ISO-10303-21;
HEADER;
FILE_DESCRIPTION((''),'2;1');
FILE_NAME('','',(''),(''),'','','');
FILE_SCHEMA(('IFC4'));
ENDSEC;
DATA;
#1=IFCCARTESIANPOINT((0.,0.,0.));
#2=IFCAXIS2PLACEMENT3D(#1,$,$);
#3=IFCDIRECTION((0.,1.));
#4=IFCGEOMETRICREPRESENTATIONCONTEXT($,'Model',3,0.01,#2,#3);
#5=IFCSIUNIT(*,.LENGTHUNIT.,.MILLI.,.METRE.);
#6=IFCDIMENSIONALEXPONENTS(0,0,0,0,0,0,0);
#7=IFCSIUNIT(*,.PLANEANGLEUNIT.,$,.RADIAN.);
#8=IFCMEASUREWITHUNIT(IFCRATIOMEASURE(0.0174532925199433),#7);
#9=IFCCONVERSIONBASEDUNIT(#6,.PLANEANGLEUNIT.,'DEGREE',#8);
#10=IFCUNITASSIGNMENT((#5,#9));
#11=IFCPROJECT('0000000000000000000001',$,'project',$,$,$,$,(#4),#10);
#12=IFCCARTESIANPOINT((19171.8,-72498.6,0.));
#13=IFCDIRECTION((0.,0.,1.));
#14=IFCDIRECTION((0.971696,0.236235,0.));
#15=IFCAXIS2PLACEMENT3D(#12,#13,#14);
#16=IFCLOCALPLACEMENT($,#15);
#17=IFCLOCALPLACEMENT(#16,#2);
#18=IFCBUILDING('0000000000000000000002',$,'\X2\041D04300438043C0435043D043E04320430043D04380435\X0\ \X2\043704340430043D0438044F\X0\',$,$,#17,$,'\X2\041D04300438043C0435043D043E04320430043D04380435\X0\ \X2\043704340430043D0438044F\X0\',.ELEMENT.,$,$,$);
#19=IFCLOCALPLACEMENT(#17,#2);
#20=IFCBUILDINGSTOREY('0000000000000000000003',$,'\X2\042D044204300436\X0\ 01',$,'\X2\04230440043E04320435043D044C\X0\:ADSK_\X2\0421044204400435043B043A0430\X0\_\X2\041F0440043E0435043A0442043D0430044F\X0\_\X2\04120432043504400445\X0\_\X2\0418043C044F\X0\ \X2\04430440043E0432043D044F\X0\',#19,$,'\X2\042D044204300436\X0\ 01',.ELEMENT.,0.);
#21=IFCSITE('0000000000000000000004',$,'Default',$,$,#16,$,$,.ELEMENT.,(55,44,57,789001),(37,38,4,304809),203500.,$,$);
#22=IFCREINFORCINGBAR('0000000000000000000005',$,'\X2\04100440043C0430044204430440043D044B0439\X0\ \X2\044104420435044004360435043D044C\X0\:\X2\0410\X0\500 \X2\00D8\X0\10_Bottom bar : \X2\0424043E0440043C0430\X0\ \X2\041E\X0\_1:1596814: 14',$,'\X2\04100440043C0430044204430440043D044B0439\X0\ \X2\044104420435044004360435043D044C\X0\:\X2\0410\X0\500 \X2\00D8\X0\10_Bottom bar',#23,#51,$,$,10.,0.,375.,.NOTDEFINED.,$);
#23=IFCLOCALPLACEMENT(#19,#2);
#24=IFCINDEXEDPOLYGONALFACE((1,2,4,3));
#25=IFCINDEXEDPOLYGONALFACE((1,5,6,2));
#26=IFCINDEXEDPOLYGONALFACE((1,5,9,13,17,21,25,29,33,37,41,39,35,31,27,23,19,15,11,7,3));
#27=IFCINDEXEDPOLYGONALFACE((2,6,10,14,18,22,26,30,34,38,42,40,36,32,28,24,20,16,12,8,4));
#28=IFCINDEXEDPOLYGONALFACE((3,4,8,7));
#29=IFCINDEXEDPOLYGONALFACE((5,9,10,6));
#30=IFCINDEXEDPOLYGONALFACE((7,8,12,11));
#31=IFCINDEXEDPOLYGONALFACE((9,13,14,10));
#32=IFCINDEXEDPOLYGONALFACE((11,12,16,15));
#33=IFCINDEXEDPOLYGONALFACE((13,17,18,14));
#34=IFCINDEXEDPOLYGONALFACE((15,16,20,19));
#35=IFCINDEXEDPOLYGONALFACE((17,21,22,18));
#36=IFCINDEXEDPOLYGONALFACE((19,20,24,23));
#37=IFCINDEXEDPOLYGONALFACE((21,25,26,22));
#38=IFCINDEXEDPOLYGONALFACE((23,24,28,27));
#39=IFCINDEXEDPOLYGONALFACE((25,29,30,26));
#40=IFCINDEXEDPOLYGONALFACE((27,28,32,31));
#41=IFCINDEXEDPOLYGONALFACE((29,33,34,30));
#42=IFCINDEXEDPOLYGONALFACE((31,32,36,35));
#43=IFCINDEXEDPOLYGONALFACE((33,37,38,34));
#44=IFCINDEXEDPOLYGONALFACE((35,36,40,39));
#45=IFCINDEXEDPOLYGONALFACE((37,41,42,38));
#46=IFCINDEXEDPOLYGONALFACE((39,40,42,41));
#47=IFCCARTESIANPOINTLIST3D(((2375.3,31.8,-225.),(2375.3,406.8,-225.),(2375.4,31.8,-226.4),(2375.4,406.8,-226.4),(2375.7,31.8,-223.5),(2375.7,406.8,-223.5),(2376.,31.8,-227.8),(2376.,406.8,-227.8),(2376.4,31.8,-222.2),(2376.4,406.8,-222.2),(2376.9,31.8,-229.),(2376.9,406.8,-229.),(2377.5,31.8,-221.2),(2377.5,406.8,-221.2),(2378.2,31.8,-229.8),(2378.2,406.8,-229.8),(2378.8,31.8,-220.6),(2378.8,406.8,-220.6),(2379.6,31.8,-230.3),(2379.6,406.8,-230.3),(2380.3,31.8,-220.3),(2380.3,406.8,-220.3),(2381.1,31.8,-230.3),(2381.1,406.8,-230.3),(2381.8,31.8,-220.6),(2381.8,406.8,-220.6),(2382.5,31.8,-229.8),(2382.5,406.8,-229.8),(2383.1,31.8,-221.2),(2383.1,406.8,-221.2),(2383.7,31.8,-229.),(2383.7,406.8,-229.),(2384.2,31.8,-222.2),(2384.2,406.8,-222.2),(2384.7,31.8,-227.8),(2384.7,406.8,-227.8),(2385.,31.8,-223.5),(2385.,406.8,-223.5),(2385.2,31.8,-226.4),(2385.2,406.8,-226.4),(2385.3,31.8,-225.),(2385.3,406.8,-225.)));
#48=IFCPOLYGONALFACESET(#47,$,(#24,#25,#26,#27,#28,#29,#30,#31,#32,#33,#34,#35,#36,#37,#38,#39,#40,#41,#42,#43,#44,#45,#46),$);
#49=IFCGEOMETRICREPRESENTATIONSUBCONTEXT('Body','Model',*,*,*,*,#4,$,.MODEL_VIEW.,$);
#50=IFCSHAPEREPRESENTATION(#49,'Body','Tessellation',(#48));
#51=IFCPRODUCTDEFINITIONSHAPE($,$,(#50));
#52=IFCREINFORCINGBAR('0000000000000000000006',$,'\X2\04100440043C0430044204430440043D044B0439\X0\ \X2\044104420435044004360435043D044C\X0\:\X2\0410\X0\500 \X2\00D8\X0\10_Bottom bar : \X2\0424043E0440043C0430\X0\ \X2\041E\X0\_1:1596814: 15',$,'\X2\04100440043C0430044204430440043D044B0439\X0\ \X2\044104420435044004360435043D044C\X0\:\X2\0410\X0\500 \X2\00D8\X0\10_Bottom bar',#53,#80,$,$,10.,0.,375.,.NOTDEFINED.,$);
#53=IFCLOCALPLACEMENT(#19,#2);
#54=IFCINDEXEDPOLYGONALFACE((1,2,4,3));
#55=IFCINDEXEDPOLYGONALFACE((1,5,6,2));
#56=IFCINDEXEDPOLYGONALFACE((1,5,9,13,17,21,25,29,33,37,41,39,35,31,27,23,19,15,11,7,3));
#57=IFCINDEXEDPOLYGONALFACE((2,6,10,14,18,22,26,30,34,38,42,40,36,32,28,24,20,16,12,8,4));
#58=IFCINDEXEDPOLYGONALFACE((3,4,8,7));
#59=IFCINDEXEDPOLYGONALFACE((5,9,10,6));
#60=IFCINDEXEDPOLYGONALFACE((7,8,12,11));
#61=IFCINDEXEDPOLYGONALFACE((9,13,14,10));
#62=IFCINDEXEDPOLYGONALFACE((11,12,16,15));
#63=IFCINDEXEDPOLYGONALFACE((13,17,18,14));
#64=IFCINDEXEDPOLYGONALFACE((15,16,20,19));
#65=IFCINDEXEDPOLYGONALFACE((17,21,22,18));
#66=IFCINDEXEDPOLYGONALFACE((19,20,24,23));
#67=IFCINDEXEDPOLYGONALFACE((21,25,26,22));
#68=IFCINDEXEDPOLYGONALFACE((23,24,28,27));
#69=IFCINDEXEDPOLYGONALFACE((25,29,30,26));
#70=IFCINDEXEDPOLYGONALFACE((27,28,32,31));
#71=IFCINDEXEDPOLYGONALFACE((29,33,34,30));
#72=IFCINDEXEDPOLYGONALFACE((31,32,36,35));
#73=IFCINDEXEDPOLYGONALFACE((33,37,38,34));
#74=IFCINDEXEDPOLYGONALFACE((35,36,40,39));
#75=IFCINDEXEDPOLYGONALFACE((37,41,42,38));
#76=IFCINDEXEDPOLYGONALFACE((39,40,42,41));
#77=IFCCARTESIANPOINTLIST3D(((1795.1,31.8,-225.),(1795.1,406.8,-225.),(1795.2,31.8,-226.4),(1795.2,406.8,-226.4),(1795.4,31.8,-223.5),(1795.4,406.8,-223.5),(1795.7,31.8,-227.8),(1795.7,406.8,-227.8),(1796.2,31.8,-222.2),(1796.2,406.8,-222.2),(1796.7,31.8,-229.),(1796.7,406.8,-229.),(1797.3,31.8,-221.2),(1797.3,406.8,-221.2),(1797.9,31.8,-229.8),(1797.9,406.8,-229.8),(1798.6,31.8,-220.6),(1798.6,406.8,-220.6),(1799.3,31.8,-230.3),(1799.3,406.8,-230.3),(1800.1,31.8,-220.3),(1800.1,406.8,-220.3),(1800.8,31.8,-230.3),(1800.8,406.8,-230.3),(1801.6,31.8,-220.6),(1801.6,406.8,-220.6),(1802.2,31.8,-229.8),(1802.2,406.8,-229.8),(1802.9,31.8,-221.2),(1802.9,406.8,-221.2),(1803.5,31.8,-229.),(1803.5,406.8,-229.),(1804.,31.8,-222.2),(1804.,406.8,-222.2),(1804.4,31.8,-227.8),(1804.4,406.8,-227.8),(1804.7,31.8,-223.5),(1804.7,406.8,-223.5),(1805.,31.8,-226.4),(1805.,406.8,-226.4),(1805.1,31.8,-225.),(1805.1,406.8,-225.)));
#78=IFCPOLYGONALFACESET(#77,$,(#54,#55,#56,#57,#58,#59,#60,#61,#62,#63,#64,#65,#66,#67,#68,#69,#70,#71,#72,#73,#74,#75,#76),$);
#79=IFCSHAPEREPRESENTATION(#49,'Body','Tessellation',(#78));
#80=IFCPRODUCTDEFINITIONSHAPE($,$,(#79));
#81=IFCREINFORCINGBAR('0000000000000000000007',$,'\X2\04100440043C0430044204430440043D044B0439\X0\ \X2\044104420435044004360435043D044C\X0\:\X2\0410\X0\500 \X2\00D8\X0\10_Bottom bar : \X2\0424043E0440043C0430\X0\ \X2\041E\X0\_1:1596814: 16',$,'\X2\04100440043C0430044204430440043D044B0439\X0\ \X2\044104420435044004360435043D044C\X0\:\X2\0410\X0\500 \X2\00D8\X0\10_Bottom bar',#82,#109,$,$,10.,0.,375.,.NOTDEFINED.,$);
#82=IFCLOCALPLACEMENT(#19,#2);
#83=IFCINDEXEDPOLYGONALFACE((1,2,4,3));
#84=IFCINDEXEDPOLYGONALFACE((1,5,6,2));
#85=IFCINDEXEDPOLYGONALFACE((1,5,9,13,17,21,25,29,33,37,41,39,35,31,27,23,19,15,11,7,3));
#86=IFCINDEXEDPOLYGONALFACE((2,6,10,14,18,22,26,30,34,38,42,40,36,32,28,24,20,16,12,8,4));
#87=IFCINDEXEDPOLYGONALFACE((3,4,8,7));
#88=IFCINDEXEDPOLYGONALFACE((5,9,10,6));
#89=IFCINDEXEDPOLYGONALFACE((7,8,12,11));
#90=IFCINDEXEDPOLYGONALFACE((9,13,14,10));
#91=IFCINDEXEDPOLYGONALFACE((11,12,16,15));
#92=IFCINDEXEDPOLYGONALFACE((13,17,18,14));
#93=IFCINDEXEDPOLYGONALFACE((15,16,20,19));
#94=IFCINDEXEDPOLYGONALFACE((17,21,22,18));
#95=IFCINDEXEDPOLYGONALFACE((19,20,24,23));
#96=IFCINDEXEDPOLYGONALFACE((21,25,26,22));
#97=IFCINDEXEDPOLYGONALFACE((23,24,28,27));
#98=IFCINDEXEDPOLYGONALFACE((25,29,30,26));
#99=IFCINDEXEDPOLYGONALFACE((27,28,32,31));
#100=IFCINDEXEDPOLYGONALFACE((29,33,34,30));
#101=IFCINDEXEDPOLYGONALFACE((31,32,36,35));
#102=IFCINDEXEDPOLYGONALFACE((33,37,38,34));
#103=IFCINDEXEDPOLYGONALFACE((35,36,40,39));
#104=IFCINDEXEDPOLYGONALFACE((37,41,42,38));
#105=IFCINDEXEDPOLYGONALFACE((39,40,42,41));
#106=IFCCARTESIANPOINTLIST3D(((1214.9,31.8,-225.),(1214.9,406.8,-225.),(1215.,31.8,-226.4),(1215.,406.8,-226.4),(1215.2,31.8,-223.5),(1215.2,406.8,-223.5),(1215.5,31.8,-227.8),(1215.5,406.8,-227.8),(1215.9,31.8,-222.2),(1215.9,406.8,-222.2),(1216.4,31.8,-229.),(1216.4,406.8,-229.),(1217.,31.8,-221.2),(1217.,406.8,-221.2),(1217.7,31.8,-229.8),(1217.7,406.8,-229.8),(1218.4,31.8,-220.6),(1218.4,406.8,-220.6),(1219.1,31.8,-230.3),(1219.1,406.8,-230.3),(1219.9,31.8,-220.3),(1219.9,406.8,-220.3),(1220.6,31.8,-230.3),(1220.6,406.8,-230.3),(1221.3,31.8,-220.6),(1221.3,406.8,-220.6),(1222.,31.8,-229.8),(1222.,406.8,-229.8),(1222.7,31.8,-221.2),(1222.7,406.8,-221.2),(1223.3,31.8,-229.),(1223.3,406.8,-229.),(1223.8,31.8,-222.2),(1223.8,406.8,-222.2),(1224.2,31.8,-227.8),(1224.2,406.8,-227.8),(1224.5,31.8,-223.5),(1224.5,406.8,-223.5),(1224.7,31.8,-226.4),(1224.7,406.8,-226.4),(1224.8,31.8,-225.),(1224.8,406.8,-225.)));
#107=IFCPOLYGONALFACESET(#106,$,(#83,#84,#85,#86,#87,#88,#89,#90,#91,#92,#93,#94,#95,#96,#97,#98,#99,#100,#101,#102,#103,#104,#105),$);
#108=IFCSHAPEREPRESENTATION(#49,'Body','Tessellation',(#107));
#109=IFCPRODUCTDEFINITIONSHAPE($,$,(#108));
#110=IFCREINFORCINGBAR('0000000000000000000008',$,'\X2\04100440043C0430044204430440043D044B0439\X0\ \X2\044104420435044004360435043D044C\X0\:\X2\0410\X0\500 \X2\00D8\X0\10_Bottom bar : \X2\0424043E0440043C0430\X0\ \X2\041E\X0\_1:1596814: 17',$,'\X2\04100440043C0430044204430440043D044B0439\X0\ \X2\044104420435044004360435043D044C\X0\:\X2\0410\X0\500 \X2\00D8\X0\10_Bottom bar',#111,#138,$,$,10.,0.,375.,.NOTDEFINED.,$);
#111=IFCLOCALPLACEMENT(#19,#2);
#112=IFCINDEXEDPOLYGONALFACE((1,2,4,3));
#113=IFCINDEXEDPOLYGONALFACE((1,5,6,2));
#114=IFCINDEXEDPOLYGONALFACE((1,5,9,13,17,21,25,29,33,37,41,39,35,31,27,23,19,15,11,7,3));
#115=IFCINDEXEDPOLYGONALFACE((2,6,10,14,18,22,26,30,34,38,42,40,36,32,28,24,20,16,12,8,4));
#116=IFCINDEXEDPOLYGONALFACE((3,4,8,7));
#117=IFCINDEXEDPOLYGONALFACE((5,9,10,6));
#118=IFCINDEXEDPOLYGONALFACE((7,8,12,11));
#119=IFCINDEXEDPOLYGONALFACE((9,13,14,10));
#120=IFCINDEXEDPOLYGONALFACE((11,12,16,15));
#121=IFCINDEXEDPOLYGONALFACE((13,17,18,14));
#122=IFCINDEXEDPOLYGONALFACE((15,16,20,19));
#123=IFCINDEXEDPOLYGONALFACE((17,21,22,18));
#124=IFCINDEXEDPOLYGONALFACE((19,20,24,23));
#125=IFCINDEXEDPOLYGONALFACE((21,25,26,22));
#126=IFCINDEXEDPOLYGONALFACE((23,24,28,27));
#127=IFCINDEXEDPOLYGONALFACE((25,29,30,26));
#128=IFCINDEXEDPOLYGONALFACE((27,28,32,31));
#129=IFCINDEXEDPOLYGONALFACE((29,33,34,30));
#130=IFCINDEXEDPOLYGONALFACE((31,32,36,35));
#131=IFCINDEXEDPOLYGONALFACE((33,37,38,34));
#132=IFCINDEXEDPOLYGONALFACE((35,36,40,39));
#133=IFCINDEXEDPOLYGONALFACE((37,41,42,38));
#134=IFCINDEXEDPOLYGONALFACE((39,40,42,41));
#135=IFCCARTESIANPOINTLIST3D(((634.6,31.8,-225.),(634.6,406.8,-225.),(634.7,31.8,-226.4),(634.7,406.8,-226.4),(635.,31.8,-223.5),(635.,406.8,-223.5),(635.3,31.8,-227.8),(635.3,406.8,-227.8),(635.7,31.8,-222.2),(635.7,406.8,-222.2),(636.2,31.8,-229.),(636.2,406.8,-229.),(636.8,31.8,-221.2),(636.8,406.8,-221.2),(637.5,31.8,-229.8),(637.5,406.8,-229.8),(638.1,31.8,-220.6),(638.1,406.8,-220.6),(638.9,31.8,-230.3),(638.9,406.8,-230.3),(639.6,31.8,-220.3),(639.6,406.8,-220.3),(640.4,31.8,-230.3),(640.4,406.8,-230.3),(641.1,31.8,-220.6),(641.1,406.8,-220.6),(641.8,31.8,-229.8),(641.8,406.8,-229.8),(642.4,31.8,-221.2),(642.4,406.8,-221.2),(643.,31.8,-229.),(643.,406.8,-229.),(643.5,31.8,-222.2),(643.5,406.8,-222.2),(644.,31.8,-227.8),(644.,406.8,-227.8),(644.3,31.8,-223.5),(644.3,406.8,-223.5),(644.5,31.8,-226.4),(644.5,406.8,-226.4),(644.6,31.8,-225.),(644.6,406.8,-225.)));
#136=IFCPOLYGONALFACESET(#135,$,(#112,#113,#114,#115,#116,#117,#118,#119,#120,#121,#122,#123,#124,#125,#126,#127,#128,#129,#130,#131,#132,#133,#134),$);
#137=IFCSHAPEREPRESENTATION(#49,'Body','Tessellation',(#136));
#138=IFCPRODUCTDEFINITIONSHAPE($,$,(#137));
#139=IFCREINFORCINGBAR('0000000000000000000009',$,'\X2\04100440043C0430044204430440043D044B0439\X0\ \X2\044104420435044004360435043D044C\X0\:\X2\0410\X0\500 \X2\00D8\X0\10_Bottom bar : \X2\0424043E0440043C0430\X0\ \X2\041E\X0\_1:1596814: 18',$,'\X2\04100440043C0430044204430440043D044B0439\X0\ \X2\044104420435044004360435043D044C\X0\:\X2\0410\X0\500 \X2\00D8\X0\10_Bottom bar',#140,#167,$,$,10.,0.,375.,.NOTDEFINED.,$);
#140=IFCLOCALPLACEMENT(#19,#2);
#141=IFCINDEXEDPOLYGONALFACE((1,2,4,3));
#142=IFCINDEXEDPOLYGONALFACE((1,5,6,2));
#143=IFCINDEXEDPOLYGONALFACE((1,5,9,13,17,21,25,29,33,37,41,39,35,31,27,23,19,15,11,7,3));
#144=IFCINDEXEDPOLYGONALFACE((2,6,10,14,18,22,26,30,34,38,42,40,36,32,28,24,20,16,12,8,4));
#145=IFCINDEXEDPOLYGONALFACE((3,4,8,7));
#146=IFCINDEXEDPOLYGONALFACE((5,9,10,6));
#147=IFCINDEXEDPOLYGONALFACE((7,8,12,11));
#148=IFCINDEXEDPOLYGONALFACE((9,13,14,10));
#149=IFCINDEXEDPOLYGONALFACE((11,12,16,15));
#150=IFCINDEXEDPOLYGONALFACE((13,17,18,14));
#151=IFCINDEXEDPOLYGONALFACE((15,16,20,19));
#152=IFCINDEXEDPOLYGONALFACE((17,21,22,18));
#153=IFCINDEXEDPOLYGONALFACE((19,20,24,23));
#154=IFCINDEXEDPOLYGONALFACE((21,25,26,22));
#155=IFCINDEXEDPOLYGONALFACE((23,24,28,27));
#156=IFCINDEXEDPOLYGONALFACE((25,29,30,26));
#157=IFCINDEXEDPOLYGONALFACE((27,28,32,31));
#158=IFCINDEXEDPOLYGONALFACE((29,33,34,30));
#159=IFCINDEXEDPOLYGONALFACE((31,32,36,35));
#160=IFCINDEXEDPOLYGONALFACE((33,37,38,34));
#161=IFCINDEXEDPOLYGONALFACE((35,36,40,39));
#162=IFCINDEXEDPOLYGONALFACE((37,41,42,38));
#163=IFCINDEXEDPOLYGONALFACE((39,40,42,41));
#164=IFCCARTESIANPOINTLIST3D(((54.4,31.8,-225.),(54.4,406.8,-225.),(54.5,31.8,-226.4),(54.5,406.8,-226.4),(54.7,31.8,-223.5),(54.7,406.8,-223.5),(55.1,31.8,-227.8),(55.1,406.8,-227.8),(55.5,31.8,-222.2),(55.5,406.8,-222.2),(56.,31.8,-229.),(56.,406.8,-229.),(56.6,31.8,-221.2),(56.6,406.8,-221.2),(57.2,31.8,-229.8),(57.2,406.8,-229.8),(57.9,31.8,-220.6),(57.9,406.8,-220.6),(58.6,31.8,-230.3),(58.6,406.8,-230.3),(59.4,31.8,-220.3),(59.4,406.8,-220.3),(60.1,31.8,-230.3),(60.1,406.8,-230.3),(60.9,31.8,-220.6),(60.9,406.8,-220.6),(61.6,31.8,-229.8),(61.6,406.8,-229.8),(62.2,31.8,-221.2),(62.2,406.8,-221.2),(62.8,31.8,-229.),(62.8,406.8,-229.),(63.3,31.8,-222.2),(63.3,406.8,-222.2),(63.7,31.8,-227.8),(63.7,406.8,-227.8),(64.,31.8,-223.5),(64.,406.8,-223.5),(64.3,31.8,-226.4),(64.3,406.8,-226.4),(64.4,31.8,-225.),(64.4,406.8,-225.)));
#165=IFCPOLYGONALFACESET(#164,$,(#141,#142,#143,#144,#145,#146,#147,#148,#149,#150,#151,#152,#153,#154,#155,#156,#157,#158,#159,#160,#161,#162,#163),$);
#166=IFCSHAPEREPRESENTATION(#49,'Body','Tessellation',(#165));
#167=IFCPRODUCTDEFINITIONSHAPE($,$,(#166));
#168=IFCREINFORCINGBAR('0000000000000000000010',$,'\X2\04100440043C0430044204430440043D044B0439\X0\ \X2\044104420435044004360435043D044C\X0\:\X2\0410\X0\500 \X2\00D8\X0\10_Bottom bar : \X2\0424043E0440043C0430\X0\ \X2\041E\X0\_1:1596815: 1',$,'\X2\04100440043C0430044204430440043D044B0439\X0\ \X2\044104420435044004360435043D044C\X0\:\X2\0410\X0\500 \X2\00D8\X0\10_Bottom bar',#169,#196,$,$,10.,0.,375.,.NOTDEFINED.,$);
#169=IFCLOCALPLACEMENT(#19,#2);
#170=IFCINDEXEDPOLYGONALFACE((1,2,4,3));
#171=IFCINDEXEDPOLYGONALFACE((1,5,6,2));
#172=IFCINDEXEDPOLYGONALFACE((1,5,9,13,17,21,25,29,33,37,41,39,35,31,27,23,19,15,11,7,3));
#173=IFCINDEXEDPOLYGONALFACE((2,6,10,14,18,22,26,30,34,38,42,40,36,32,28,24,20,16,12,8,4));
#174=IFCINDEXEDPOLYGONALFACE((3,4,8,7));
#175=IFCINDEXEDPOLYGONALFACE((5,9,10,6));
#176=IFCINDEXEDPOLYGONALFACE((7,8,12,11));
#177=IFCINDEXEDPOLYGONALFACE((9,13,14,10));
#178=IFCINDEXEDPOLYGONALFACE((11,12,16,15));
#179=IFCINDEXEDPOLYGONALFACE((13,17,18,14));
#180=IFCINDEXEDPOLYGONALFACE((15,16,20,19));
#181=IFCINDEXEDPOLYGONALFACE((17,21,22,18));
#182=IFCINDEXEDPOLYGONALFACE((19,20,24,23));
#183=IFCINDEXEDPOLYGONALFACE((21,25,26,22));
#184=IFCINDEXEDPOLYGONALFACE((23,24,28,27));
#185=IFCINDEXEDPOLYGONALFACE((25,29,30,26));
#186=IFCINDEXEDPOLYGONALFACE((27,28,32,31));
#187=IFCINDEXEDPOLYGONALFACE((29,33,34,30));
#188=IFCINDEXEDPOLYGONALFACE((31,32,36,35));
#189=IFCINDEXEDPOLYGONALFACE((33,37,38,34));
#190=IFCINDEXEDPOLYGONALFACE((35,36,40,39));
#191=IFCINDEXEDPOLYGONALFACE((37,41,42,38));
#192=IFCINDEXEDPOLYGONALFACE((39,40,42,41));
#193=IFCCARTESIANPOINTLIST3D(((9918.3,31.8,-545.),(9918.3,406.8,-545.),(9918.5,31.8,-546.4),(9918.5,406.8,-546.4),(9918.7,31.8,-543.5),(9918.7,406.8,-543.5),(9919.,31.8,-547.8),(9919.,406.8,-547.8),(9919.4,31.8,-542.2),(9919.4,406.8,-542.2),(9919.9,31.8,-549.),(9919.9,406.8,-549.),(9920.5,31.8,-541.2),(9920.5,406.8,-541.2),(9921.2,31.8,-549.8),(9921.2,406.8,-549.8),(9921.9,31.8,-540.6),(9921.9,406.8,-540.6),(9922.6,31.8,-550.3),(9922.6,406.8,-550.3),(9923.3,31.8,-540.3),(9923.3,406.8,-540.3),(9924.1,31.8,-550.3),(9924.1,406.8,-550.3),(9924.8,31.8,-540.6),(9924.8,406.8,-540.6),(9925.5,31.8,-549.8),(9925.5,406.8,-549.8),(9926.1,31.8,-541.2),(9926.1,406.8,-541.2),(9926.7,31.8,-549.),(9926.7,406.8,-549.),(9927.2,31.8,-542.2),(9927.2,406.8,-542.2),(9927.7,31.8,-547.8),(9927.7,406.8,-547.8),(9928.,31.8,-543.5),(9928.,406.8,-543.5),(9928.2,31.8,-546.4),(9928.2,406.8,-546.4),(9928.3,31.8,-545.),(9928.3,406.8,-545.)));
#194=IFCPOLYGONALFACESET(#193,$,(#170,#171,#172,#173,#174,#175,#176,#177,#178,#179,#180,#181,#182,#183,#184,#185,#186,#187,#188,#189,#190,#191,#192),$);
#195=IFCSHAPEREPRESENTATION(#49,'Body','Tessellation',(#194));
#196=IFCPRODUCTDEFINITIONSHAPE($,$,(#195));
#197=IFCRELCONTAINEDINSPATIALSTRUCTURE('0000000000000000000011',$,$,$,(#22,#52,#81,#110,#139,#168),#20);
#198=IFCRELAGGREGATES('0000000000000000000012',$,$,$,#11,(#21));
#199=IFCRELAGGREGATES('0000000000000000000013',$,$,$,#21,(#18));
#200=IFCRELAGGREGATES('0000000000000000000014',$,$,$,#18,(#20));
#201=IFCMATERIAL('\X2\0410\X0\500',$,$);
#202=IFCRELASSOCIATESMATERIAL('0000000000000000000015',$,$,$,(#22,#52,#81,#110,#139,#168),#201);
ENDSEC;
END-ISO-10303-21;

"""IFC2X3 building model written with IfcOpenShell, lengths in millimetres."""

from ifc_helpers import new_model, entity, si_unit, converted_unit, direction, frame, origin, place, context, subcontext, project, spatial, material, element, save


model = new_model("IFC2X3")

# Units and contexts
model_context = context("Model", 3, precision=0.01, world=origin(), true_north=direction((0.0, 1.0)))
body_context = subcontext(model_context, "Body", "Model", "MODEL_VIEW")
ifc_project = project(units=[si_unit("LENGTHUNIT", "METRE", prefix="MILLI"), converted_unit("PLANEANGLEUNIT", "DEGREE", entity("IfcRatioMeasure", 0.0174532925199433), si_unit("PLANEANGLEUNIT", "RADIAN"), dimensions=[0, 0, 0, 0, 0, 0, 0])], contexts=[model_context])

# Site, building, storey
site_placement = place(None, frame((19171.8, -72498.6, 0.0), z_axis=(0.0, 0.0, 1.0), x_axis=(0.971696, 0.236235, 0.0)))
site = spatial("IfcSite", under=ifc_project, at=site_placement, Name="Default", CompositionType="ELEMENT", RefLatitude=(55, 44, 57, 789001), RefLongitude=(37, 38, 4, 304809), RefElevation=203500.0)
building_placement = place(site_placement, origin())
building = spatial("IfcBuilding", under=site, at=building_placement, Name="Наименование здания", LongName="Наименование здания", CompositionType="ELEMENT")
storey_placement = place(building_placement, origin())
storey = spatial("IfcBuildingStorey", under=building, at=storey_placement, Name="Этаж 01", ObjectType="Уровень:ADSK_Стрелка_Проектная_Вверх_Имя уровня", LongName="Этаж 01", CompositionType="ELEMENT", Elevation=0.0)

# Reinforcing bars
ifc_material = material(Name="А500")
placement = place(storey_placement, origin())
element("IfcReinforcingBar", 1, at=placement, inside=storey, material=ifc_material, Name="Арматурный стержень:А500 Ø10_Bottom bar : Форма О_1:1596814: 14", ObjectType="Арматурный стержень:А500 Ø10_Bottom bar", BarLength=375.0, BarRole="NOTDEFINED", CrossSectionArea=0.0, NominalDiameter=10.0, context=body_context, shape_type="AdvancedSweptSolid", body=[
    entity("IfcSweptDiskSolid", entity("IfcCompositeCurve", [entity("IfcCompositeCurveSegment", "CONTINUOUS", True, entity("IfcPolyline", [entity("IfcCartesianPoint", [2380.3, 31.8, -225.3]), entity("IfcCartesianPoint", [2380.3, 406.8, -225.3])]))], False), 5.0, None, 0.0, 1.0),
])
element("IfcReinforcingBar", 2, at=placement, inside=storey, material=ifc_material, Name="Арматурный стержень:А500 Ø10_Bottom bar : Форма О_1:1596814: 15", ObjectType="Арматурный стержень:А500 Ø10_Bottom bar", BarLength=375.0, BarRole="NOTDEFINED", CrossSectionArea=0.0, NominalDiameter=10.0, context=body_context, shape_type="AdvancedSweptSolid", body=[
    entity("IfcSweptDiskSolid", entity("IfcCompositeCurve", [entity("IfcCompositeCurveSegment", "CONTINUOUS", True, entity("IfcPolyline", [entity("IfcCartesianPoint", [1800.1, 31.8, -225.3]), entity("IfcCartesianPoint", [1800.1, 406.8, -225.3])]))], False), 5.0, None, 0.0, 1.0),
])
element("IfcReinforcingBar", 3, at=placement, inside=storey, material=ifc_material, Name="Арматурный стержень:А500 Ø10_Bottom bar : Форма О_1:1596814: 16", ObjectType="Арматурный стержень:А500 Ø10_Bottom bar", BarLength=375.0, BarRole="NOTDEFINED", CrossSectionArea=0.0, NominalDiameter=10.0, context=body_context, shape_type="AdvancedSweptSolid", body=[
    entity("IfcSweptDiskSolid", entity("IfcCompositeCurve", [entity("IfcCompositeCurveSegment", "CONTINUOUS", True, entity("IfcPolyline", [entity("IfcCartesianPoint", [1219.8, 31.8, -225.3]), entity("IfcCartesianPoint", [1219.8, 406.8, -225.3])]))], False), 5.0, None, 0.0, 1.0),
])
element("IfcReinforcingBar", 4, at=placement, inside=storey, material=ifc_material, Name="Арматурный стержень:А500 Ø10_Bottom bar : Форма О_1:1596814: 17", ObjectType="Арматурный стержень:А500 Ø10_Bottom bar", BarLength=375.0, BarRole="NOTDEFINED", CrossSectionArea=0.0, NominalDiameter=10.0, context=body_context, shape_type="AdvancedSweptSolid", body=[
    entity("IfcSweptDiskSolid", entity("IfcCompositeCurve", [entity("IfcCompositeCurveSegment", "CONTINUOUS", True, entity("IfcPolyline", [entity("IfcCartesianPoint", [639.6, 31.8, -225.3]), entity("IfcCartesianPoint", [639.6, 406.8, -225.3])]))], False), 5.0, None, 0.0, 1.0),
])
element("IfcReinforcingBar", 5, at=placement, inside=storey, material=ifc_material, Name="Арматурный стержень:А500 Ø10_Bottom bar : Форма О_1:1596814: 18", ObjectType="Арматурный стержень:А500 Ø10_Bottom bar", BarLength=375.0, BarRole="NOTDEFINED", CrossSectionArea=0.0, NominalDiameter=10.0, context=body_context, shape_type="AdvancedSweptSolid", body=[
    entity("IfcSweptDiskSolid", entity("IfcCompositeCurve", [entity("IfcCompositeCurveSegment", "CONTINUOUS", True, entity("IfcPolyline", [entity("IfcCartesianPoint", [59.4, 31.8, -225.3]), entity("IfcCartesianPoint", [59.4, 406.8, -225.3])]))], False), 5.0, None, 0.0, 1.0),
])
element("IfcReinforcingBar", 6, at=placement, inside=storey, material=ifc_material, Name="Арматурный стержень:А500 Ø10_Bottom bar : Форма О_1:1596815: 1", ObjectType="Арматурный стержень:А500 Ø10_Bottom bar", BarLength=375.0, BarRole="NOTDEFINED", CrossSectionArea=0.0, NominalDiameter=10.0, context=body_context, shape_type="AdvancedSweptSolid", body=[
    entity("IfcSweptDiskSolid", entity("IfcCompositeCurve", [entity("IfcCompositeCurveSegment", "CONTINUOUS", True, entity("IfcPolyline", [entity("IfcCartesianPoint", [9923.3, 31.8, -545.3]), entity("IfcCartesianPoint", [9923.3, 406.8, -545.3])]))], False), 5.0, None, 0.0, 1.0),
])

save(model, "model.ifc")
